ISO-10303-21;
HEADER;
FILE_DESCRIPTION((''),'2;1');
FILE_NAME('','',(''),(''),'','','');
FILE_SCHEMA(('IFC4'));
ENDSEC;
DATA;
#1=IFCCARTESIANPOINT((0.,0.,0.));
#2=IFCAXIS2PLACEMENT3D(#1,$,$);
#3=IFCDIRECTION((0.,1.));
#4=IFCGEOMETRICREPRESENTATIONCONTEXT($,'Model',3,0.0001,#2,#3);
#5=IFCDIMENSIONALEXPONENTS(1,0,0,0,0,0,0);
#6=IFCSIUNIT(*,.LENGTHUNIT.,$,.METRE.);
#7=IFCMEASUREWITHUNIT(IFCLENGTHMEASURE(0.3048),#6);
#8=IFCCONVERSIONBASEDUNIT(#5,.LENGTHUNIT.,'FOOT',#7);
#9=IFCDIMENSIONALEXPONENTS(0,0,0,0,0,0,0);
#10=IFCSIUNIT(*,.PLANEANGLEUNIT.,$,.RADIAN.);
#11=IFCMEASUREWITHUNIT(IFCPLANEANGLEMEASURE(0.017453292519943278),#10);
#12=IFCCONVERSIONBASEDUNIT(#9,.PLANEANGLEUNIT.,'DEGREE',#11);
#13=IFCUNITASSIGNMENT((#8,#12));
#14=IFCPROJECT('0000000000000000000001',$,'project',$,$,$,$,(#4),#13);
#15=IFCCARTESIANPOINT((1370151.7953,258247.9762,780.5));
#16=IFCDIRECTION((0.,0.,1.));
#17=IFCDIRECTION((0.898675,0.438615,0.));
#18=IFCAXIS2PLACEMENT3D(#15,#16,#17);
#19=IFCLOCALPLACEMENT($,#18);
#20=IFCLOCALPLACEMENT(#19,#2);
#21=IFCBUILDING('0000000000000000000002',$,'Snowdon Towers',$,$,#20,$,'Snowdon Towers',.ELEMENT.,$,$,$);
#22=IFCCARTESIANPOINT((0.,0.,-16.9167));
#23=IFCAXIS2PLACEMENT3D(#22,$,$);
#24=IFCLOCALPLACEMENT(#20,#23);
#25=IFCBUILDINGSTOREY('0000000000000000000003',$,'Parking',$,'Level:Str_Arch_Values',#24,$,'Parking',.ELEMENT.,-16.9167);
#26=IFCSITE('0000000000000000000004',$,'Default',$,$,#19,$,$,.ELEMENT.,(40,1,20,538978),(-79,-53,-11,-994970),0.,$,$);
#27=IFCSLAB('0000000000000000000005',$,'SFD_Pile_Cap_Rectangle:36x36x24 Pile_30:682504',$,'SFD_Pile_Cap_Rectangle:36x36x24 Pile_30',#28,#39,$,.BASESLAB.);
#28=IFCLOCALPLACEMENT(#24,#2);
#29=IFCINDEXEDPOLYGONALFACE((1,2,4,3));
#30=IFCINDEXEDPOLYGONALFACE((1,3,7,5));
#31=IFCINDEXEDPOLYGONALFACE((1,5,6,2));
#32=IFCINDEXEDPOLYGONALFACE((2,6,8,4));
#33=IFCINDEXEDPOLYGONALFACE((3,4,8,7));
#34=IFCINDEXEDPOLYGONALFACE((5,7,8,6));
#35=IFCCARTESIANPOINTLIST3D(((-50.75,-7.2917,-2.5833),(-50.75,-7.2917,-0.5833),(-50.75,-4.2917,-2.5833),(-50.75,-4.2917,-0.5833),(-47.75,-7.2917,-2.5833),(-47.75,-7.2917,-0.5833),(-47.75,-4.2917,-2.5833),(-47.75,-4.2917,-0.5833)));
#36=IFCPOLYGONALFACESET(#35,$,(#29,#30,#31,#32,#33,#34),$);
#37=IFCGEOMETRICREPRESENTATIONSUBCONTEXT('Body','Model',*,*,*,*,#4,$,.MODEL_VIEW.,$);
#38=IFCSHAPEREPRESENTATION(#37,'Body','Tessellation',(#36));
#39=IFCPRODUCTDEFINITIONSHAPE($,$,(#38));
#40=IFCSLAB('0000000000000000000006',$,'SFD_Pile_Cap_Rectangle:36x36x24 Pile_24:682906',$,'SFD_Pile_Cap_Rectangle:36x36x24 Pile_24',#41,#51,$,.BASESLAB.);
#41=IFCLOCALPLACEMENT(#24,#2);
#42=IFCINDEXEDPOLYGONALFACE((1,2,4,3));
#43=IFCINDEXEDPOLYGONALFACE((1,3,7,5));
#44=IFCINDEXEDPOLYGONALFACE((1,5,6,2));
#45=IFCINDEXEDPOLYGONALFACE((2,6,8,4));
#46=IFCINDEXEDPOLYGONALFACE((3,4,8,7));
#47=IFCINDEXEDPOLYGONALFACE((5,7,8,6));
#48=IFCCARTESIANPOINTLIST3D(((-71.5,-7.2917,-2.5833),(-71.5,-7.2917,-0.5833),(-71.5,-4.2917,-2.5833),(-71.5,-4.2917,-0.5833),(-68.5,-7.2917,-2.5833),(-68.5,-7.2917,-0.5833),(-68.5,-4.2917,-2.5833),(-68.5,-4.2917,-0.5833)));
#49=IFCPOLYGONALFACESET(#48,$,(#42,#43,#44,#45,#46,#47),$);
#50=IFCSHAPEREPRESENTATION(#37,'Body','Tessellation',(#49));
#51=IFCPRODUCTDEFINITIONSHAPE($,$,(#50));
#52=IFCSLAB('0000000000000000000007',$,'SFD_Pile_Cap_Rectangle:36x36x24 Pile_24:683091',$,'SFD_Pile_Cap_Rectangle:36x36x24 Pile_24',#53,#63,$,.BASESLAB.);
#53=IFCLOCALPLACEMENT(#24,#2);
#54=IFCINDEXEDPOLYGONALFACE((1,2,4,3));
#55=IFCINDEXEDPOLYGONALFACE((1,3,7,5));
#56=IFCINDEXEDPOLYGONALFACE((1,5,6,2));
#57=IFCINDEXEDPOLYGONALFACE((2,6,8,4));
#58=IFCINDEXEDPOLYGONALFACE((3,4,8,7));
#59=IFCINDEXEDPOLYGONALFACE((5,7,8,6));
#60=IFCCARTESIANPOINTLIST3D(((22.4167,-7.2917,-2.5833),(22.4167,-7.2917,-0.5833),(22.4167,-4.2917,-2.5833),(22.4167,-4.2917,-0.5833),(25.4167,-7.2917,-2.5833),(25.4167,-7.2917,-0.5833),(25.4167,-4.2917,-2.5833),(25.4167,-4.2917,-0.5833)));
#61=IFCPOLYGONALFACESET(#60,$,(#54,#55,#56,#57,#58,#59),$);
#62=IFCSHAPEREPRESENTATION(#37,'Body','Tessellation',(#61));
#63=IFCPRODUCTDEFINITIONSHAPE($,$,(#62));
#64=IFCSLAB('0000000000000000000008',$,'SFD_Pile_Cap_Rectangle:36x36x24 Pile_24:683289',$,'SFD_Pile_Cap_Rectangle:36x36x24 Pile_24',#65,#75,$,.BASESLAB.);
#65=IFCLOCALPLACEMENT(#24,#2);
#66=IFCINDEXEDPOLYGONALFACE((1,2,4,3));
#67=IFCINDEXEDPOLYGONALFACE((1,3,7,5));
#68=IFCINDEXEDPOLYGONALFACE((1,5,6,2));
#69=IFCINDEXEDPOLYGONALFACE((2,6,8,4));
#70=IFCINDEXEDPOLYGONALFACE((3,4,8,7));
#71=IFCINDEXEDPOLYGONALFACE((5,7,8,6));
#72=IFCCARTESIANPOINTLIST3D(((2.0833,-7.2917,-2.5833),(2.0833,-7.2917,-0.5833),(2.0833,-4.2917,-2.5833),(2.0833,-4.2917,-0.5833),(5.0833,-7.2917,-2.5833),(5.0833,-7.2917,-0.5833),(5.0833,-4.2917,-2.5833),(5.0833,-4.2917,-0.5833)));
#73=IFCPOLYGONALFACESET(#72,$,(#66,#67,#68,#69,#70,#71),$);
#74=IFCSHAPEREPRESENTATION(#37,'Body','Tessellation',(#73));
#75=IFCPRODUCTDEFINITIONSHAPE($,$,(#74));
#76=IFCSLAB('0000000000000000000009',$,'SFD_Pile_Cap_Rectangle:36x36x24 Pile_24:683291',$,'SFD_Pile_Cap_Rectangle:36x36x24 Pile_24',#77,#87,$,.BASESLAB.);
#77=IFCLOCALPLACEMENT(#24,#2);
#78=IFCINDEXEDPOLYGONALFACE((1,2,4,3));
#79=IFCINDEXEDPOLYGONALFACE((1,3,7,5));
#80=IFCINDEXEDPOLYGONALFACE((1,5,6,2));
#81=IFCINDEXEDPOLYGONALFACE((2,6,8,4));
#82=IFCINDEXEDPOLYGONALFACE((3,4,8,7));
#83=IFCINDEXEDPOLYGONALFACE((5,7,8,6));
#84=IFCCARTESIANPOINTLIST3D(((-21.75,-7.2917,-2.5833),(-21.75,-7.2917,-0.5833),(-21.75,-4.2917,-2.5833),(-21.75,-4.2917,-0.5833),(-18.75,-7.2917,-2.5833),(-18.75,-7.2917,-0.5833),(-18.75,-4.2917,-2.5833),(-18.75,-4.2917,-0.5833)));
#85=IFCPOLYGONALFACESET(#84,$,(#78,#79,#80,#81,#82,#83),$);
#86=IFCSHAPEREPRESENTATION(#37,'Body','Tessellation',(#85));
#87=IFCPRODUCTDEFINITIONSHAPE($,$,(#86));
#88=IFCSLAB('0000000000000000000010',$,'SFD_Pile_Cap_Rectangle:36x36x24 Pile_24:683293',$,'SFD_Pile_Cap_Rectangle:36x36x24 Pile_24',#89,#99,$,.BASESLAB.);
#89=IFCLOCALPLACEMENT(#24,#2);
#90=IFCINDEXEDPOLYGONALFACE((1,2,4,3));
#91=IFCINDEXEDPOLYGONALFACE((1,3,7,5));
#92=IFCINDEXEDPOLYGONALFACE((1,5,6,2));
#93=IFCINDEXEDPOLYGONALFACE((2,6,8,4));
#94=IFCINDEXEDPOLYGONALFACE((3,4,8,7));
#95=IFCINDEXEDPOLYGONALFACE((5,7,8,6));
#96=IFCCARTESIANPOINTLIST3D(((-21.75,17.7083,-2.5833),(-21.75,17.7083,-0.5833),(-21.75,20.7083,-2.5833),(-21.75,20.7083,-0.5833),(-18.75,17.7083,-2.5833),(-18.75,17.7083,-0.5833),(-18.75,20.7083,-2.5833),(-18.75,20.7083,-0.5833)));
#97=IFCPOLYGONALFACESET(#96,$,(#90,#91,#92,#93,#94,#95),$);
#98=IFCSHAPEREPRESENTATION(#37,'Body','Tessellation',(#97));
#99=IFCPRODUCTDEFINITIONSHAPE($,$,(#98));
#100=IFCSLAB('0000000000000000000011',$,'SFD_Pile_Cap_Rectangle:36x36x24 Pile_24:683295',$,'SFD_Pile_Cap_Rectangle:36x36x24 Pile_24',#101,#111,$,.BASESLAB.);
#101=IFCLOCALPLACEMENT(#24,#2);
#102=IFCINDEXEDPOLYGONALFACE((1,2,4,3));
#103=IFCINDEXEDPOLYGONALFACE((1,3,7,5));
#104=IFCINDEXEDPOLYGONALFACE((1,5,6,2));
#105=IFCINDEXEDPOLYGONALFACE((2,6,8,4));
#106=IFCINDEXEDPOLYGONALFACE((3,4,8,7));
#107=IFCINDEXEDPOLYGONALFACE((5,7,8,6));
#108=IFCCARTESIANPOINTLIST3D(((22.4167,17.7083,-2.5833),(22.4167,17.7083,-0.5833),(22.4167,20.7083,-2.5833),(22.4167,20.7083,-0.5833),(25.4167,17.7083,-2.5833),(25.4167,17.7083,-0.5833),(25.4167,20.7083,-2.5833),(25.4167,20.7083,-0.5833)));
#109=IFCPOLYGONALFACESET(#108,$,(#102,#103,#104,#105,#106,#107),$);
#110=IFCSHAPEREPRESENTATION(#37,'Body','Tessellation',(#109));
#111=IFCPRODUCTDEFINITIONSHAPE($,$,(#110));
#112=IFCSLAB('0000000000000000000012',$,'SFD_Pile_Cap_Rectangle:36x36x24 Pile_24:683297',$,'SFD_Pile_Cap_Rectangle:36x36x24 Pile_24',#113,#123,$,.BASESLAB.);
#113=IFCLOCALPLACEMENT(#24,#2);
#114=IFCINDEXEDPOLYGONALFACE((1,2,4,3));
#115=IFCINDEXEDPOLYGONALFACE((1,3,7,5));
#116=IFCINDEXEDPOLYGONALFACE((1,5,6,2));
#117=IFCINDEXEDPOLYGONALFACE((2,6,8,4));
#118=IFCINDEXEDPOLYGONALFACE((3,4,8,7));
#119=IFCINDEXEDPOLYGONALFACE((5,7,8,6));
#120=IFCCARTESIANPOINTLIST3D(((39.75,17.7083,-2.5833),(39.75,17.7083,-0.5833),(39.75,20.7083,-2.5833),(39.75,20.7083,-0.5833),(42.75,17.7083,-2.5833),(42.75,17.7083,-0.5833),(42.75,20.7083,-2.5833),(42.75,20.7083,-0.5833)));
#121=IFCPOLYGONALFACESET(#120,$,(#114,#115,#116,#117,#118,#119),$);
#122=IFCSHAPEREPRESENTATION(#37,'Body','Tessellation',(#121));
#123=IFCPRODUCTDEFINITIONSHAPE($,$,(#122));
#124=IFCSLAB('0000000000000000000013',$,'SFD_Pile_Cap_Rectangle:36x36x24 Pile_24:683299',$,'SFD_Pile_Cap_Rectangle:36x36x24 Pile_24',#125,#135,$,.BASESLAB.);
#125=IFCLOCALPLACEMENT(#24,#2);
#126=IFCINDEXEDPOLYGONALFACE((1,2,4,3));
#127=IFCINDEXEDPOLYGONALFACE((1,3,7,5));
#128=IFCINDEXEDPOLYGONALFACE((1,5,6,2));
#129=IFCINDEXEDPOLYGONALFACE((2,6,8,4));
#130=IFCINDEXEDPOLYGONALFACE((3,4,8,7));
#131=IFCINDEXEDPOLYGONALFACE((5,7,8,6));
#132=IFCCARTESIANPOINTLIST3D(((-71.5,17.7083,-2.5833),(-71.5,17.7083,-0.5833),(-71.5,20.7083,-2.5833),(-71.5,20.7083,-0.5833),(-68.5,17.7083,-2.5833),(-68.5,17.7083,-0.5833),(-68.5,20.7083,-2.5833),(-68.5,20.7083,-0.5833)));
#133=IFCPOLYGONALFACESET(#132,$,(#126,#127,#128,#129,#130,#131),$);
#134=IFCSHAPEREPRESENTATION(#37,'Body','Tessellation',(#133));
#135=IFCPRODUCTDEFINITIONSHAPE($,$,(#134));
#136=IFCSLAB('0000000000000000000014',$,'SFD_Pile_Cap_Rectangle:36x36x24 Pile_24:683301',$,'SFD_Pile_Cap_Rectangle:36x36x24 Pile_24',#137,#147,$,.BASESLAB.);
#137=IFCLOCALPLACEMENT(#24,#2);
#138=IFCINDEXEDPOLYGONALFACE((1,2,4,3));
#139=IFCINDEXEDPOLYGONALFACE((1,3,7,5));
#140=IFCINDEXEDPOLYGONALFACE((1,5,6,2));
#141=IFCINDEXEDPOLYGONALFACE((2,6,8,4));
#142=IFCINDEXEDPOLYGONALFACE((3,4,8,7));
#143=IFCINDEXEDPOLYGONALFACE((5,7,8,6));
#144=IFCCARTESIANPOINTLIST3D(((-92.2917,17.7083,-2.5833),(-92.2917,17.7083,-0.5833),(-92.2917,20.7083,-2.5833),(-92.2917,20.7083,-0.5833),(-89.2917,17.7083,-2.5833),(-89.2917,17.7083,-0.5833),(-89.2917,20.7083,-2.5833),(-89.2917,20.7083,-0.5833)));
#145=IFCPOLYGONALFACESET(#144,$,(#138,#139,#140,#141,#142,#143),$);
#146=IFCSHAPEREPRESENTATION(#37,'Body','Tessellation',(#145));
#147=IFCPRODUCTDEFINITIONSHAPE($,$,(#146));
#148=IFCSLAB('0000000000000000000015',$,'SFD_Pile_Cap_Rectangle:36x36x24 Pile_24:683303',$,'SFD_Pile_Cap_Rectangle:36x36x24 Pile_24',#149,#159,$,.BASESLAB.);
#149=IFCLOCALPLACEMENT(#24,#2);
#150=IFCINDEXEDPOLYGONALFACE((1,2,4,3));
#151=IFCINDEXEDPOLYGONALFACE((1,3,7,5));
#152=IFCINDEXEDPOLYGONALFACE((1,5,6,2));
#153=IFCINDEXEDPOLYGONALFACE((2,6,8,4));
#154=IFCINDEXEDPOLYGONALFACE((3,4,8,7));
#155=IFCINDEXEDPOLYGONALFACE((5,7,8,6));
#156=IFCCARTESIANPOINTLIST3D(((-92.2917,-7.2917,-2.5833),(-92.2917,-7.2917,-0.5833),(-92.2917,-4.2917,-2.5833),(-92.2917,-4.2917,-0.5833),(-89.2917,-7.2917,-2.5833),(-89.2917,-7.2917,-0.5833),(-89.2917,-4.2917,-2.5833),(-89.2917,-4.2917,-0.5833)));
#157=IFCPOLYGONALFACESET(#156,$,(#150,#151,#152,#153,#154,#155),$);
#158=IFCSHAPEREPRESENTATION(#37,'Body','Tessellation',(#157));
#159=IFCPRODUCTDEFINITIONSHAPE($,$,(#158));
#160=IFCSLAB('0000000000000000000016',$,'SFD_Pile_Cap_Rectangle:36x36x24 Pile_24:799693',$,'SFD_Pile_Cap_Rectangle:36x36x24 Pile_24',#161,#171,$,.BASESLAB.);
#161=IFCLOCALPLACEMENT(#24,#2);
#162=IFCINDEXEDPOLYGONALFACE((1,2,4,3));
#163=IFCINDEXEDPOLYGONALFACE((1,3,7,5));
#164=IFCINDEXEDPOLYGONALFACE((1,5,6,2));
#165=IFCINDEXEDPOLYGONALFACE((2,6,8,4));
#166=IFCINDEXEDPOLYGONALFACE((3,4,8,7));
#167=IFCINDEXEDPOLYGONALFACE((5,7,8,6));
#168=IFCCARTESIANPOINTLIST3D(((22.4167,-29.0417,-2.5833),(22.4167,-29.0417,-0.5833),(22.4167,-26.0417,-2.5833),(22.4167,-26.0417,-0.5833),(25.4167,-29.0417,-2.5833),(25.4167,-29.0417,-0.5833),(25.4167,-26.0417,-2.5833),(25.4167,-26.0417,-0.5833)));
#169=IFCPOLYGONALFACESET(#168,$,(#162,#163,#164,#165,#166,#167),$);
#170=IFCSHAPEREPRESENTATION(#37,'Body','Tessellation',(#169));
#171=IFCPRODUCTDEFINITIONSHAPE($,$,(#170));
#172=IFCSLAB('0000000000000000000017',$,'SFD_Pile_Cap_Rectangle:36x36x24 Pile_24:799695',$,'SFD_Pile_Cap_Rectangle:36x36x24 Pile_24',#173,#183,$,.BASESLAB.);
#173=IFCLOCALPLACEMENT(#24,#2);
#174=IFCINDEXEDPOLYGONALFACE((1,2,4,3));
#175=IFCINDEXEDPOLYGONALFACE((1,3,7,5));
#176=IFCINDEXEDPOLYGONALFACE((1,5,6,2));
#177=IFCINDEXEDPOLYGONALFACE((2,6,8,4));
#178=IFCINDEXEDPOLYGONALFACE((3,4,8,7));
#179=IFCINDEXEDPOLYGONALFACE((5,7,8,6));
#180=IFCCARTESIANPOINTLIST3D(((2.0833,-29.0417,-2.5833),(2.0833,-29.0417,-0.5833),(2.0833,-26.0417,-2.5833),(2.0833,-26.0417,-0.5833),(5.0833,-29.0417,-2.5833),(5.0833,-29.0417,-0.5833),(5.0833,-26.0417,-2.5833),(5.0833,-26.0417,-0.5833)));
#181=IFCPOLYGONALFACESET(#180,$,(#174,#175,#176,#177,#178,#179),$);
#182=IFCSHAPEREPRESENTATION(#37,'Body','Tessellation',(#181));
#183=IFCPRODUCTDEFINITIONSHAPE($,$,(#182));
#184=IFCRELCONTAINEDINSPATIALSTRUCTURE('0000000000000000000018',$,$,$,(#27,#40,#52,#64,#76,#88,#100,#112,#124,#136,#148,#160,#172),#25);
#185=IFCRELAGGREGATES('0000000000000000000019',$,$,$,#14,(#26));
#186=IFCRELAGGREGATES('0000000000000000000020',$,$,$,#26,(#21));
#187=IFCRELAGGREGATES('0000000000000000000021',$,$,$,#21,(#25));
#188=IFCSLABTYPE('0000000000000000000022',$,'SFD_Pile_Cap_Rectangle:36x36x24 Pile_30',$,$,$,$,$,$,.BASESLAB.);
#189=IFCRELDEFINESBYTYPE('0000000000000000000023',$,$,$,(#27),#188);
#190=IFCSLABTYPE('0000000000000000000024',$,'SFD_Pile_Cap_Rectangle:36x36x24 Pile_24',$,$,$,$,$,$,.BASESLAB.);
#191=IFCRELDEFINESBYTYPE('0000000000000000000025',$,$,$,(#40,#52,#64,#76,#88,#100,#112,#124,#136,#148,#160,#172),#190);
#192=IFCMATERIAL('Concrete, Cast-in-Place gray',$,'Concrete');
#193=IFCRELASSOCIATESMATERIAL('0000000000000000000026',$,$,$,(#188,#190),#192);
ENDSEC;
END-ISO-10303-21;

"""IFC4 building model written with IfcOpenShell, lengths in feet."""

from ifc_helpers import new_model, entity, si_unit, converted_unit, direction, frame, origin, place, context, subcontext, project, spatial, indexed_curve, outline, extrude, material, type_object, element, save


model = new_model("IFC4")

# Units and contexts
model_context = context("Model", 3, precision=0.0001, world=origin(), true_north=direction((0.0, 1.0)))
body_context = subcontext(model_context, "Body", "Model", "MODEL_VIEW")
ifc_project = project(units=[converted_unit("LENGTHUNIT", "FOOT", entity("IfcLengthMeasure", 0.3048), si_unit("LENGTHUNIT", "METRE"), dimensions=[1, 0, 0, 0, 0, 0, 0]), converted_unit("PLANEANGLEUNIT", "DEGREE", entity("IfcPlaneAngleMeasure", 0.017453292519943278), si_unit("PLANEANGLEUNIT", "RADIAN"), dimensions=[0, 0, 0, 0, 0, 0, 0])], contexts=[model_context])

# Site, building, storey
site_placement = place(None, frame((1370151.7953, 258247.9762, 780.5), z_axis=(0.0, 0.0, 1.0), x_axis=(0.898675, 0.438615, 0.0)))
site = spatial("IfcSite", under=ifc_project, at=site_placement, Name="Default", CompositionType="ELEMENT", RefLatitude=(40, 1, 20, 538978), RefLongitude=(-79, -53, -11, -994970), RefElevation=0.0)
building_placement = place(site_placement, origin())
building = spatial("IfcBuilding", under=site, at=building_placement, Name="Snowdon Towers", LongName="Snowdon Towers", CompositionType="ELEMENT")
storey_placement = place(building_placement, frame((0.0, 0.0, -16.9167)))
storey = spatial("IfcBuildingStorey", under=building, at=storey_placement, Name="Parking", ObjectType="Level:Str_Arch_Values", LongName="Parking", CompositionType="ELEMENT", Elevation=-16.9167)

# Slabs
ifc_material = material(Name="Concrete, Cast-in-Place gray", Category="Concrete")
slab_type_1 = type_object("IfcSlabType", Name="SFD_Pile_Cap_Rectangle:36x36x24 Pile_30", PredefinedType="BASESLAB", material=ifc_material)
slab_1_placement = place(storey_placement, origin())
element("IfcSlab", 1, at=slab_1_placement, inside=storey, type_object=slab_type_1, Name="SFD_Pile_Cap_Rectangle:36x36x24 Pile_30:682504", ObjectType="SFD_Pile_Cap_Rectangle:36x36x24 Pile_30", PredefinedType="BASESLAB", context=body_context, shape_type="SweptSolid", body=[
    extrude(outline(indexed_curve([(-1.5, -1.5), (1.5, -1.5), (1.5, 1.5), (-1.5, 1.5), (-1.5, -1.5)], self_intersect=False)), frame((-49.25, -5.7917, -2.5833), z_axis=(0.0, 0.0, 1.0), x_axis=(-1.0, 0.0, 0.0)), (0.0, 0.0, 1.0), 2.0),
])
slab_type_2 = type_object("IfcSlabType", Name="SFD_Pile_Cap_Rectangle:36x36x24 Pile_24", PredefinedType="BASESLAB", material=ifc_material)
slab_2_placement = place(storey_placement, origin())
element("IfcSlab", 2, at=slab_2_placement, inside=storey, type_object=slab_type_2, Name="SFD_Pile_Cap_Rectangle:36x36x24 Pile_24:682906", ObjectType="SFD_Pile_Cap_Rectangle:36x36x24 Pile_24", PredefinedType="BASESLAB", context=body_context, shape_type="SweptSolid", body=[
    extrude(outline(indexed_curve([(-1.5, -1.5), (1.5, -1.5), (1.5, 1.5), (-1.5, 1.5), (-1.5, -1.5)], self_intersect=False)), frame((-70.0, -5.7917, -2.5833), z_axis=(0.0, 0.0, 1.0), x_axis=(-1.0, 0.0, 0.0)), (0.0, 0.0, 1.0), 2.0),
])
slab_3_placement = place(storey_placement, origin())
element("IfcSlab", 3, at=slab_3_placement, inside=storey, type_object=slab_type_2, Name="SFD_Pile_Cap_Rectangle:36x36x24 Pile_24:683091", ObjectType="SFD_Pile_Cap_Rectangle:36x36x24 Pile_24", PredefinedType="BASESLAB", context=body_context, shape_type="SweptSolid", body=[
    extrude(outline(indexed_curve([(-1.5, -1.5), (1.5, -1.5), (1.5, 1.5), (-1.5, 1.5), (-1.5, -1.5)], self_intersect=False)), frame((23.9167, -5.7917, -2.5833), z_axis=(0.0, 0.0, 1.0), x_axis=(-1.0, 0.0, 0.0)), (0.0, 0.0, 1.0), 2.0),
])
slab_4_placement = place(storey_placement, origin())
element("IfcSlab", 4, at=slab_4_placement, inside=storey, type_object=slab_type_2, Name="SFD_Pile_Cap_Rectangle:36x36x24 Pile_24:683289", ObjectType="SFD_Pile_Cap_Rectangle:36x36x24 Pile_24", PredefinedType="BASESLAB", context=body_context, shape_type="SweptSolid", body=[
    extrude(outline(indexed_curve([(-1.5, -1.5), (1.5, -1.5), (1.5, 1.5), (-1.5, 1.5), (-1.5, -1.5)], self_intersect=False)), frame((3.5833, -5.7917, -2.5833), z_axis=(0.0, 0.0, 1.0), x_axis=(-1.0, 0.0, 0.0)), (0.0, 0.0, 1.0), 2.0),
])
slab_5_placement = place(storey_placement, origin())
element("IfcSlab", 5, at=slab_5_placement, inside=storey, type_object=slab_type_2, Name="SFD_Pile_Cap_Rectangle:36x36x24 Pile_24:683291", ObjectType="SFD_Pile_Cap_Rectangle:36x36x24 Pile_24", PredefinedType="BASESLAB", context=body_context, shape_type="SweptSolid", body=[
    extrude(outline(indexed_curve([(-1.5, -1.5), (1.5, -1.5), (1.5, 1.5), (-1.5, 1.5), (-1.5, -1.5)], self_intersect=False)), frame((-20.25, -5.7917, -2.5833), z_axis=(0.0, 0.0, 1.0), x_axis=(-1.0, 0.0, 0.0)), (0.0, 0.0, 1.0), 2.0),
])
slab_6_placement = place(storey_placement, origin())
element("IfcSlab", 6, at=slab_6_placement, inside=storey, type_object=slab_type_2, Name="SFD_Pile_Cap_Rectangle:36x36x24 Pile_24:683293", ObjectType="SFD_Pile_Cap_Rectangle:36x36x24 Pile_24", PredefinedType="BASESLAB", context=body_context, shape_type="SweptSolid", body=[
    extrude(outline(indexed_curve([(-1.5, -1.5), (1.5, -1.5), (1.5, 1.5), (-1.5, 1.5), (-1.5, -1.5)], self_intersect=False)), frame((-20.25, 19.2083, -2.5833), z_axis=(0.0, 0.0, 1.0), x_axis=(-1.0, 0.0, 0.0)), (0.0, 0.0, 1.0), 2.0),
])
slab_7_placement = place(storey_placement, origin())
element("IfcSlab", 7, at=slab_7_placement, inside=storey, type_object=slab_type_2, Name="SFD_Pile_Cap_Rectangle:36x36x24 Pile_24:683295", ObjectType="SFD_Pile_Cap_Rectangle:36x36x24 Pile_24", PredefinedType="BASESLAB", context=body_context, shape_type="SweptSolid", body=[
    extrude(outline(indexed_curve([(-1.5, -1.5), (1.5, -1.5), (1.5, 1.5), (-1.5, 1.5), (-1.5, -1.5)], self_intersect=False)), frame((23.9167, 19.2083, -2.5833), z_axis=(0.0, 0.0, 1.0), x_axis=(-1.0, 0.0, 0.0)), (0.0, 0.0, 1.0), 2.0),
])
slab_8_placement = place(storey_placement, origin())
element("IfcSlab", 8, at=slab_8_placement, inside=storey, type_object=slab_type_2, Name="SFD_Pile_Cap_Rectangle:36x36x24 Pile_24:683297", ObjectType="SFD_Pile_Cap_Rectangle:36x36x24 Pile_24", PredefinedType="BASESLAB", context=body_context, shape_type="SweptSolid", body=[
    extrude(outline(indexed_curve([(-1.5, -1.5), (1.5, -1.5), (1.5, 1.5), (-1.5, 1.5), (-1.5, -1.5)], self_intersect=False)), frame((41.25, 19.2083, -2.5833), z_axis=(0.0, 0.0, 1.0), x_axis=(-1.0, 0.0, 0.0)), (0.0, 0.0, 1.0), 2.0),
])
slab_9_placement = place(storey_placement, origin())
element("IfcSlab", 9, at=slab_9_placement, inside=storey, type_object=slab_type_2, Name="SFD_Pile_Cap_Rectangle:36x36x24 Pile_24:683299", ObjectType="SFD_Pile_Cap_Rectangle:36x36x24 Pile_24", PredefinedType="BASESLAB", context=body_context, shape_type="SweptSolid", body=[
    extrude(outline(indexed_curve([(-1.5, -1.5), (1.5, -1.5), (1.5, 1.5), (-1.5, 1.5), (-1.5, -1.5)], self_intersect=False)), frame((-70.0, 19.2083, -2.5833), z_axis=(0.0, 0.0, 1.0), x_axis=(-1.0, 0.0, 0.0)), (0.0, 0.0, 1.0), 2.0),
])
slab_10_placement = place(storey_placement, origin())
element("IfcSlab", 10, at=slab_10_placement, inside=storey, type_object=slab_type_2, Name="SFD_Pile_Cap_Rectangle:36x36x24 Pile_24:683301", ObjectType="SFD_Pile_Cap_Rectangle:36x36x24 Pile_24", PredefinedType="BASESLAB", context=body_context, shape_type="SweptSolid", body=[
    extrude(outline(indexed_curve([(-1.5, -1.5), (1.5, -1.5), (1.5, 1.5), (-1.5, 1.5), (-1.5, -1.5)], self_intersect=False)), frame((-90.7917, 19.2083, -2.5833), z_axis=(0.0, 0.0, 1.0), x_axis=(-1.0, 0.0, 0.0)), (0.0, 0.0, 1.0), 2.0),
])
slab_11_placement = place(storey_placement, origin())
element("IfcSlab", 11, at=slab_11_placement, inside=storey, type_object=slab_type_2, Name="SFD_Pile_Cap_Rectangle:36x36x24 Pile_24:683303", ObjectType="SFD_Pile_Cap_Rectangle:36x36x24 Pile_24", PredefinedType="BASESLAB", context=body_context, shape_type="SweptSolid", body=[
    extrude(outline(indexed_curve([(-1.5, -1.5), (1.5, -1.5), (1.5, 1.5), (-1.5, 1.5), (-1.5, -1.5)], self_intersect=False)), frame((-90.7917, -5.7917, -2.5833), z_axis=(0.0, 0.0, 1.0), x_axis=(-1.0, 0.0, 0.0)), (0.0, 0.0, 1.0), 2.0),
])
slab_12_placement = place(storey_placement, origin())
element("IfcSlab", 12, at=slab_12_placement, inside=storey, type_object=slab_type_2, Name="SFD_Pile_Cap_Rectangle:36x36x24 Pile_24:799693", ObjectType="SFD_Pile_Cap_Rectangle:36x36x24 Pile_24", PredefinedType="BASESLAB", context=body_context, shape_type="SweptSolid", body=[
    extrude(outline(indexed_curve([(-1.5, -1.5), (1.5, -1.5), (1.5, 1.5), (-1.5, 1.5), (-1.5, -1.5)], self_intersect=False)), frame((23.9167, -27.5417, -2.5833), z_axis=(0.0, 0.0, 1.0), x_axis=(-1.0, 0.0, 0.0)), (0.0, 0.0, 1.0), 2.0),
])
slab_13_placement = place(storey_placement, origin())
element("IfcSlab", 13, at=slab_13_placement, inside=storey, type_object=slab_type_2, Name="SFD_Pile_Cap_Rectangle:36x36x24 Pile_24:799695", ObjectType="SFD_Pile_Cap_Rectangle:36x36x24 Pile_24", PredefinedType="BASESLAB", context=body_context, shape_type="SweptSolid", body=[
    extrude(outline(indexed_curve([(-1.5, -1.5), (1.5, -1.5), (1.5, 1.5), (-1.5, 1.5), (-1.5, -1.5)], self_intersect=False)), frame((3.5833, -27.5417, -2.5833), z_axis=(0.0, 0.0, 1.0), x_axis=(-1.0, 0.0, 0.0)), (0.0, 0.0, 1.0), 2.0),
])

save(model, "model.ifc")
